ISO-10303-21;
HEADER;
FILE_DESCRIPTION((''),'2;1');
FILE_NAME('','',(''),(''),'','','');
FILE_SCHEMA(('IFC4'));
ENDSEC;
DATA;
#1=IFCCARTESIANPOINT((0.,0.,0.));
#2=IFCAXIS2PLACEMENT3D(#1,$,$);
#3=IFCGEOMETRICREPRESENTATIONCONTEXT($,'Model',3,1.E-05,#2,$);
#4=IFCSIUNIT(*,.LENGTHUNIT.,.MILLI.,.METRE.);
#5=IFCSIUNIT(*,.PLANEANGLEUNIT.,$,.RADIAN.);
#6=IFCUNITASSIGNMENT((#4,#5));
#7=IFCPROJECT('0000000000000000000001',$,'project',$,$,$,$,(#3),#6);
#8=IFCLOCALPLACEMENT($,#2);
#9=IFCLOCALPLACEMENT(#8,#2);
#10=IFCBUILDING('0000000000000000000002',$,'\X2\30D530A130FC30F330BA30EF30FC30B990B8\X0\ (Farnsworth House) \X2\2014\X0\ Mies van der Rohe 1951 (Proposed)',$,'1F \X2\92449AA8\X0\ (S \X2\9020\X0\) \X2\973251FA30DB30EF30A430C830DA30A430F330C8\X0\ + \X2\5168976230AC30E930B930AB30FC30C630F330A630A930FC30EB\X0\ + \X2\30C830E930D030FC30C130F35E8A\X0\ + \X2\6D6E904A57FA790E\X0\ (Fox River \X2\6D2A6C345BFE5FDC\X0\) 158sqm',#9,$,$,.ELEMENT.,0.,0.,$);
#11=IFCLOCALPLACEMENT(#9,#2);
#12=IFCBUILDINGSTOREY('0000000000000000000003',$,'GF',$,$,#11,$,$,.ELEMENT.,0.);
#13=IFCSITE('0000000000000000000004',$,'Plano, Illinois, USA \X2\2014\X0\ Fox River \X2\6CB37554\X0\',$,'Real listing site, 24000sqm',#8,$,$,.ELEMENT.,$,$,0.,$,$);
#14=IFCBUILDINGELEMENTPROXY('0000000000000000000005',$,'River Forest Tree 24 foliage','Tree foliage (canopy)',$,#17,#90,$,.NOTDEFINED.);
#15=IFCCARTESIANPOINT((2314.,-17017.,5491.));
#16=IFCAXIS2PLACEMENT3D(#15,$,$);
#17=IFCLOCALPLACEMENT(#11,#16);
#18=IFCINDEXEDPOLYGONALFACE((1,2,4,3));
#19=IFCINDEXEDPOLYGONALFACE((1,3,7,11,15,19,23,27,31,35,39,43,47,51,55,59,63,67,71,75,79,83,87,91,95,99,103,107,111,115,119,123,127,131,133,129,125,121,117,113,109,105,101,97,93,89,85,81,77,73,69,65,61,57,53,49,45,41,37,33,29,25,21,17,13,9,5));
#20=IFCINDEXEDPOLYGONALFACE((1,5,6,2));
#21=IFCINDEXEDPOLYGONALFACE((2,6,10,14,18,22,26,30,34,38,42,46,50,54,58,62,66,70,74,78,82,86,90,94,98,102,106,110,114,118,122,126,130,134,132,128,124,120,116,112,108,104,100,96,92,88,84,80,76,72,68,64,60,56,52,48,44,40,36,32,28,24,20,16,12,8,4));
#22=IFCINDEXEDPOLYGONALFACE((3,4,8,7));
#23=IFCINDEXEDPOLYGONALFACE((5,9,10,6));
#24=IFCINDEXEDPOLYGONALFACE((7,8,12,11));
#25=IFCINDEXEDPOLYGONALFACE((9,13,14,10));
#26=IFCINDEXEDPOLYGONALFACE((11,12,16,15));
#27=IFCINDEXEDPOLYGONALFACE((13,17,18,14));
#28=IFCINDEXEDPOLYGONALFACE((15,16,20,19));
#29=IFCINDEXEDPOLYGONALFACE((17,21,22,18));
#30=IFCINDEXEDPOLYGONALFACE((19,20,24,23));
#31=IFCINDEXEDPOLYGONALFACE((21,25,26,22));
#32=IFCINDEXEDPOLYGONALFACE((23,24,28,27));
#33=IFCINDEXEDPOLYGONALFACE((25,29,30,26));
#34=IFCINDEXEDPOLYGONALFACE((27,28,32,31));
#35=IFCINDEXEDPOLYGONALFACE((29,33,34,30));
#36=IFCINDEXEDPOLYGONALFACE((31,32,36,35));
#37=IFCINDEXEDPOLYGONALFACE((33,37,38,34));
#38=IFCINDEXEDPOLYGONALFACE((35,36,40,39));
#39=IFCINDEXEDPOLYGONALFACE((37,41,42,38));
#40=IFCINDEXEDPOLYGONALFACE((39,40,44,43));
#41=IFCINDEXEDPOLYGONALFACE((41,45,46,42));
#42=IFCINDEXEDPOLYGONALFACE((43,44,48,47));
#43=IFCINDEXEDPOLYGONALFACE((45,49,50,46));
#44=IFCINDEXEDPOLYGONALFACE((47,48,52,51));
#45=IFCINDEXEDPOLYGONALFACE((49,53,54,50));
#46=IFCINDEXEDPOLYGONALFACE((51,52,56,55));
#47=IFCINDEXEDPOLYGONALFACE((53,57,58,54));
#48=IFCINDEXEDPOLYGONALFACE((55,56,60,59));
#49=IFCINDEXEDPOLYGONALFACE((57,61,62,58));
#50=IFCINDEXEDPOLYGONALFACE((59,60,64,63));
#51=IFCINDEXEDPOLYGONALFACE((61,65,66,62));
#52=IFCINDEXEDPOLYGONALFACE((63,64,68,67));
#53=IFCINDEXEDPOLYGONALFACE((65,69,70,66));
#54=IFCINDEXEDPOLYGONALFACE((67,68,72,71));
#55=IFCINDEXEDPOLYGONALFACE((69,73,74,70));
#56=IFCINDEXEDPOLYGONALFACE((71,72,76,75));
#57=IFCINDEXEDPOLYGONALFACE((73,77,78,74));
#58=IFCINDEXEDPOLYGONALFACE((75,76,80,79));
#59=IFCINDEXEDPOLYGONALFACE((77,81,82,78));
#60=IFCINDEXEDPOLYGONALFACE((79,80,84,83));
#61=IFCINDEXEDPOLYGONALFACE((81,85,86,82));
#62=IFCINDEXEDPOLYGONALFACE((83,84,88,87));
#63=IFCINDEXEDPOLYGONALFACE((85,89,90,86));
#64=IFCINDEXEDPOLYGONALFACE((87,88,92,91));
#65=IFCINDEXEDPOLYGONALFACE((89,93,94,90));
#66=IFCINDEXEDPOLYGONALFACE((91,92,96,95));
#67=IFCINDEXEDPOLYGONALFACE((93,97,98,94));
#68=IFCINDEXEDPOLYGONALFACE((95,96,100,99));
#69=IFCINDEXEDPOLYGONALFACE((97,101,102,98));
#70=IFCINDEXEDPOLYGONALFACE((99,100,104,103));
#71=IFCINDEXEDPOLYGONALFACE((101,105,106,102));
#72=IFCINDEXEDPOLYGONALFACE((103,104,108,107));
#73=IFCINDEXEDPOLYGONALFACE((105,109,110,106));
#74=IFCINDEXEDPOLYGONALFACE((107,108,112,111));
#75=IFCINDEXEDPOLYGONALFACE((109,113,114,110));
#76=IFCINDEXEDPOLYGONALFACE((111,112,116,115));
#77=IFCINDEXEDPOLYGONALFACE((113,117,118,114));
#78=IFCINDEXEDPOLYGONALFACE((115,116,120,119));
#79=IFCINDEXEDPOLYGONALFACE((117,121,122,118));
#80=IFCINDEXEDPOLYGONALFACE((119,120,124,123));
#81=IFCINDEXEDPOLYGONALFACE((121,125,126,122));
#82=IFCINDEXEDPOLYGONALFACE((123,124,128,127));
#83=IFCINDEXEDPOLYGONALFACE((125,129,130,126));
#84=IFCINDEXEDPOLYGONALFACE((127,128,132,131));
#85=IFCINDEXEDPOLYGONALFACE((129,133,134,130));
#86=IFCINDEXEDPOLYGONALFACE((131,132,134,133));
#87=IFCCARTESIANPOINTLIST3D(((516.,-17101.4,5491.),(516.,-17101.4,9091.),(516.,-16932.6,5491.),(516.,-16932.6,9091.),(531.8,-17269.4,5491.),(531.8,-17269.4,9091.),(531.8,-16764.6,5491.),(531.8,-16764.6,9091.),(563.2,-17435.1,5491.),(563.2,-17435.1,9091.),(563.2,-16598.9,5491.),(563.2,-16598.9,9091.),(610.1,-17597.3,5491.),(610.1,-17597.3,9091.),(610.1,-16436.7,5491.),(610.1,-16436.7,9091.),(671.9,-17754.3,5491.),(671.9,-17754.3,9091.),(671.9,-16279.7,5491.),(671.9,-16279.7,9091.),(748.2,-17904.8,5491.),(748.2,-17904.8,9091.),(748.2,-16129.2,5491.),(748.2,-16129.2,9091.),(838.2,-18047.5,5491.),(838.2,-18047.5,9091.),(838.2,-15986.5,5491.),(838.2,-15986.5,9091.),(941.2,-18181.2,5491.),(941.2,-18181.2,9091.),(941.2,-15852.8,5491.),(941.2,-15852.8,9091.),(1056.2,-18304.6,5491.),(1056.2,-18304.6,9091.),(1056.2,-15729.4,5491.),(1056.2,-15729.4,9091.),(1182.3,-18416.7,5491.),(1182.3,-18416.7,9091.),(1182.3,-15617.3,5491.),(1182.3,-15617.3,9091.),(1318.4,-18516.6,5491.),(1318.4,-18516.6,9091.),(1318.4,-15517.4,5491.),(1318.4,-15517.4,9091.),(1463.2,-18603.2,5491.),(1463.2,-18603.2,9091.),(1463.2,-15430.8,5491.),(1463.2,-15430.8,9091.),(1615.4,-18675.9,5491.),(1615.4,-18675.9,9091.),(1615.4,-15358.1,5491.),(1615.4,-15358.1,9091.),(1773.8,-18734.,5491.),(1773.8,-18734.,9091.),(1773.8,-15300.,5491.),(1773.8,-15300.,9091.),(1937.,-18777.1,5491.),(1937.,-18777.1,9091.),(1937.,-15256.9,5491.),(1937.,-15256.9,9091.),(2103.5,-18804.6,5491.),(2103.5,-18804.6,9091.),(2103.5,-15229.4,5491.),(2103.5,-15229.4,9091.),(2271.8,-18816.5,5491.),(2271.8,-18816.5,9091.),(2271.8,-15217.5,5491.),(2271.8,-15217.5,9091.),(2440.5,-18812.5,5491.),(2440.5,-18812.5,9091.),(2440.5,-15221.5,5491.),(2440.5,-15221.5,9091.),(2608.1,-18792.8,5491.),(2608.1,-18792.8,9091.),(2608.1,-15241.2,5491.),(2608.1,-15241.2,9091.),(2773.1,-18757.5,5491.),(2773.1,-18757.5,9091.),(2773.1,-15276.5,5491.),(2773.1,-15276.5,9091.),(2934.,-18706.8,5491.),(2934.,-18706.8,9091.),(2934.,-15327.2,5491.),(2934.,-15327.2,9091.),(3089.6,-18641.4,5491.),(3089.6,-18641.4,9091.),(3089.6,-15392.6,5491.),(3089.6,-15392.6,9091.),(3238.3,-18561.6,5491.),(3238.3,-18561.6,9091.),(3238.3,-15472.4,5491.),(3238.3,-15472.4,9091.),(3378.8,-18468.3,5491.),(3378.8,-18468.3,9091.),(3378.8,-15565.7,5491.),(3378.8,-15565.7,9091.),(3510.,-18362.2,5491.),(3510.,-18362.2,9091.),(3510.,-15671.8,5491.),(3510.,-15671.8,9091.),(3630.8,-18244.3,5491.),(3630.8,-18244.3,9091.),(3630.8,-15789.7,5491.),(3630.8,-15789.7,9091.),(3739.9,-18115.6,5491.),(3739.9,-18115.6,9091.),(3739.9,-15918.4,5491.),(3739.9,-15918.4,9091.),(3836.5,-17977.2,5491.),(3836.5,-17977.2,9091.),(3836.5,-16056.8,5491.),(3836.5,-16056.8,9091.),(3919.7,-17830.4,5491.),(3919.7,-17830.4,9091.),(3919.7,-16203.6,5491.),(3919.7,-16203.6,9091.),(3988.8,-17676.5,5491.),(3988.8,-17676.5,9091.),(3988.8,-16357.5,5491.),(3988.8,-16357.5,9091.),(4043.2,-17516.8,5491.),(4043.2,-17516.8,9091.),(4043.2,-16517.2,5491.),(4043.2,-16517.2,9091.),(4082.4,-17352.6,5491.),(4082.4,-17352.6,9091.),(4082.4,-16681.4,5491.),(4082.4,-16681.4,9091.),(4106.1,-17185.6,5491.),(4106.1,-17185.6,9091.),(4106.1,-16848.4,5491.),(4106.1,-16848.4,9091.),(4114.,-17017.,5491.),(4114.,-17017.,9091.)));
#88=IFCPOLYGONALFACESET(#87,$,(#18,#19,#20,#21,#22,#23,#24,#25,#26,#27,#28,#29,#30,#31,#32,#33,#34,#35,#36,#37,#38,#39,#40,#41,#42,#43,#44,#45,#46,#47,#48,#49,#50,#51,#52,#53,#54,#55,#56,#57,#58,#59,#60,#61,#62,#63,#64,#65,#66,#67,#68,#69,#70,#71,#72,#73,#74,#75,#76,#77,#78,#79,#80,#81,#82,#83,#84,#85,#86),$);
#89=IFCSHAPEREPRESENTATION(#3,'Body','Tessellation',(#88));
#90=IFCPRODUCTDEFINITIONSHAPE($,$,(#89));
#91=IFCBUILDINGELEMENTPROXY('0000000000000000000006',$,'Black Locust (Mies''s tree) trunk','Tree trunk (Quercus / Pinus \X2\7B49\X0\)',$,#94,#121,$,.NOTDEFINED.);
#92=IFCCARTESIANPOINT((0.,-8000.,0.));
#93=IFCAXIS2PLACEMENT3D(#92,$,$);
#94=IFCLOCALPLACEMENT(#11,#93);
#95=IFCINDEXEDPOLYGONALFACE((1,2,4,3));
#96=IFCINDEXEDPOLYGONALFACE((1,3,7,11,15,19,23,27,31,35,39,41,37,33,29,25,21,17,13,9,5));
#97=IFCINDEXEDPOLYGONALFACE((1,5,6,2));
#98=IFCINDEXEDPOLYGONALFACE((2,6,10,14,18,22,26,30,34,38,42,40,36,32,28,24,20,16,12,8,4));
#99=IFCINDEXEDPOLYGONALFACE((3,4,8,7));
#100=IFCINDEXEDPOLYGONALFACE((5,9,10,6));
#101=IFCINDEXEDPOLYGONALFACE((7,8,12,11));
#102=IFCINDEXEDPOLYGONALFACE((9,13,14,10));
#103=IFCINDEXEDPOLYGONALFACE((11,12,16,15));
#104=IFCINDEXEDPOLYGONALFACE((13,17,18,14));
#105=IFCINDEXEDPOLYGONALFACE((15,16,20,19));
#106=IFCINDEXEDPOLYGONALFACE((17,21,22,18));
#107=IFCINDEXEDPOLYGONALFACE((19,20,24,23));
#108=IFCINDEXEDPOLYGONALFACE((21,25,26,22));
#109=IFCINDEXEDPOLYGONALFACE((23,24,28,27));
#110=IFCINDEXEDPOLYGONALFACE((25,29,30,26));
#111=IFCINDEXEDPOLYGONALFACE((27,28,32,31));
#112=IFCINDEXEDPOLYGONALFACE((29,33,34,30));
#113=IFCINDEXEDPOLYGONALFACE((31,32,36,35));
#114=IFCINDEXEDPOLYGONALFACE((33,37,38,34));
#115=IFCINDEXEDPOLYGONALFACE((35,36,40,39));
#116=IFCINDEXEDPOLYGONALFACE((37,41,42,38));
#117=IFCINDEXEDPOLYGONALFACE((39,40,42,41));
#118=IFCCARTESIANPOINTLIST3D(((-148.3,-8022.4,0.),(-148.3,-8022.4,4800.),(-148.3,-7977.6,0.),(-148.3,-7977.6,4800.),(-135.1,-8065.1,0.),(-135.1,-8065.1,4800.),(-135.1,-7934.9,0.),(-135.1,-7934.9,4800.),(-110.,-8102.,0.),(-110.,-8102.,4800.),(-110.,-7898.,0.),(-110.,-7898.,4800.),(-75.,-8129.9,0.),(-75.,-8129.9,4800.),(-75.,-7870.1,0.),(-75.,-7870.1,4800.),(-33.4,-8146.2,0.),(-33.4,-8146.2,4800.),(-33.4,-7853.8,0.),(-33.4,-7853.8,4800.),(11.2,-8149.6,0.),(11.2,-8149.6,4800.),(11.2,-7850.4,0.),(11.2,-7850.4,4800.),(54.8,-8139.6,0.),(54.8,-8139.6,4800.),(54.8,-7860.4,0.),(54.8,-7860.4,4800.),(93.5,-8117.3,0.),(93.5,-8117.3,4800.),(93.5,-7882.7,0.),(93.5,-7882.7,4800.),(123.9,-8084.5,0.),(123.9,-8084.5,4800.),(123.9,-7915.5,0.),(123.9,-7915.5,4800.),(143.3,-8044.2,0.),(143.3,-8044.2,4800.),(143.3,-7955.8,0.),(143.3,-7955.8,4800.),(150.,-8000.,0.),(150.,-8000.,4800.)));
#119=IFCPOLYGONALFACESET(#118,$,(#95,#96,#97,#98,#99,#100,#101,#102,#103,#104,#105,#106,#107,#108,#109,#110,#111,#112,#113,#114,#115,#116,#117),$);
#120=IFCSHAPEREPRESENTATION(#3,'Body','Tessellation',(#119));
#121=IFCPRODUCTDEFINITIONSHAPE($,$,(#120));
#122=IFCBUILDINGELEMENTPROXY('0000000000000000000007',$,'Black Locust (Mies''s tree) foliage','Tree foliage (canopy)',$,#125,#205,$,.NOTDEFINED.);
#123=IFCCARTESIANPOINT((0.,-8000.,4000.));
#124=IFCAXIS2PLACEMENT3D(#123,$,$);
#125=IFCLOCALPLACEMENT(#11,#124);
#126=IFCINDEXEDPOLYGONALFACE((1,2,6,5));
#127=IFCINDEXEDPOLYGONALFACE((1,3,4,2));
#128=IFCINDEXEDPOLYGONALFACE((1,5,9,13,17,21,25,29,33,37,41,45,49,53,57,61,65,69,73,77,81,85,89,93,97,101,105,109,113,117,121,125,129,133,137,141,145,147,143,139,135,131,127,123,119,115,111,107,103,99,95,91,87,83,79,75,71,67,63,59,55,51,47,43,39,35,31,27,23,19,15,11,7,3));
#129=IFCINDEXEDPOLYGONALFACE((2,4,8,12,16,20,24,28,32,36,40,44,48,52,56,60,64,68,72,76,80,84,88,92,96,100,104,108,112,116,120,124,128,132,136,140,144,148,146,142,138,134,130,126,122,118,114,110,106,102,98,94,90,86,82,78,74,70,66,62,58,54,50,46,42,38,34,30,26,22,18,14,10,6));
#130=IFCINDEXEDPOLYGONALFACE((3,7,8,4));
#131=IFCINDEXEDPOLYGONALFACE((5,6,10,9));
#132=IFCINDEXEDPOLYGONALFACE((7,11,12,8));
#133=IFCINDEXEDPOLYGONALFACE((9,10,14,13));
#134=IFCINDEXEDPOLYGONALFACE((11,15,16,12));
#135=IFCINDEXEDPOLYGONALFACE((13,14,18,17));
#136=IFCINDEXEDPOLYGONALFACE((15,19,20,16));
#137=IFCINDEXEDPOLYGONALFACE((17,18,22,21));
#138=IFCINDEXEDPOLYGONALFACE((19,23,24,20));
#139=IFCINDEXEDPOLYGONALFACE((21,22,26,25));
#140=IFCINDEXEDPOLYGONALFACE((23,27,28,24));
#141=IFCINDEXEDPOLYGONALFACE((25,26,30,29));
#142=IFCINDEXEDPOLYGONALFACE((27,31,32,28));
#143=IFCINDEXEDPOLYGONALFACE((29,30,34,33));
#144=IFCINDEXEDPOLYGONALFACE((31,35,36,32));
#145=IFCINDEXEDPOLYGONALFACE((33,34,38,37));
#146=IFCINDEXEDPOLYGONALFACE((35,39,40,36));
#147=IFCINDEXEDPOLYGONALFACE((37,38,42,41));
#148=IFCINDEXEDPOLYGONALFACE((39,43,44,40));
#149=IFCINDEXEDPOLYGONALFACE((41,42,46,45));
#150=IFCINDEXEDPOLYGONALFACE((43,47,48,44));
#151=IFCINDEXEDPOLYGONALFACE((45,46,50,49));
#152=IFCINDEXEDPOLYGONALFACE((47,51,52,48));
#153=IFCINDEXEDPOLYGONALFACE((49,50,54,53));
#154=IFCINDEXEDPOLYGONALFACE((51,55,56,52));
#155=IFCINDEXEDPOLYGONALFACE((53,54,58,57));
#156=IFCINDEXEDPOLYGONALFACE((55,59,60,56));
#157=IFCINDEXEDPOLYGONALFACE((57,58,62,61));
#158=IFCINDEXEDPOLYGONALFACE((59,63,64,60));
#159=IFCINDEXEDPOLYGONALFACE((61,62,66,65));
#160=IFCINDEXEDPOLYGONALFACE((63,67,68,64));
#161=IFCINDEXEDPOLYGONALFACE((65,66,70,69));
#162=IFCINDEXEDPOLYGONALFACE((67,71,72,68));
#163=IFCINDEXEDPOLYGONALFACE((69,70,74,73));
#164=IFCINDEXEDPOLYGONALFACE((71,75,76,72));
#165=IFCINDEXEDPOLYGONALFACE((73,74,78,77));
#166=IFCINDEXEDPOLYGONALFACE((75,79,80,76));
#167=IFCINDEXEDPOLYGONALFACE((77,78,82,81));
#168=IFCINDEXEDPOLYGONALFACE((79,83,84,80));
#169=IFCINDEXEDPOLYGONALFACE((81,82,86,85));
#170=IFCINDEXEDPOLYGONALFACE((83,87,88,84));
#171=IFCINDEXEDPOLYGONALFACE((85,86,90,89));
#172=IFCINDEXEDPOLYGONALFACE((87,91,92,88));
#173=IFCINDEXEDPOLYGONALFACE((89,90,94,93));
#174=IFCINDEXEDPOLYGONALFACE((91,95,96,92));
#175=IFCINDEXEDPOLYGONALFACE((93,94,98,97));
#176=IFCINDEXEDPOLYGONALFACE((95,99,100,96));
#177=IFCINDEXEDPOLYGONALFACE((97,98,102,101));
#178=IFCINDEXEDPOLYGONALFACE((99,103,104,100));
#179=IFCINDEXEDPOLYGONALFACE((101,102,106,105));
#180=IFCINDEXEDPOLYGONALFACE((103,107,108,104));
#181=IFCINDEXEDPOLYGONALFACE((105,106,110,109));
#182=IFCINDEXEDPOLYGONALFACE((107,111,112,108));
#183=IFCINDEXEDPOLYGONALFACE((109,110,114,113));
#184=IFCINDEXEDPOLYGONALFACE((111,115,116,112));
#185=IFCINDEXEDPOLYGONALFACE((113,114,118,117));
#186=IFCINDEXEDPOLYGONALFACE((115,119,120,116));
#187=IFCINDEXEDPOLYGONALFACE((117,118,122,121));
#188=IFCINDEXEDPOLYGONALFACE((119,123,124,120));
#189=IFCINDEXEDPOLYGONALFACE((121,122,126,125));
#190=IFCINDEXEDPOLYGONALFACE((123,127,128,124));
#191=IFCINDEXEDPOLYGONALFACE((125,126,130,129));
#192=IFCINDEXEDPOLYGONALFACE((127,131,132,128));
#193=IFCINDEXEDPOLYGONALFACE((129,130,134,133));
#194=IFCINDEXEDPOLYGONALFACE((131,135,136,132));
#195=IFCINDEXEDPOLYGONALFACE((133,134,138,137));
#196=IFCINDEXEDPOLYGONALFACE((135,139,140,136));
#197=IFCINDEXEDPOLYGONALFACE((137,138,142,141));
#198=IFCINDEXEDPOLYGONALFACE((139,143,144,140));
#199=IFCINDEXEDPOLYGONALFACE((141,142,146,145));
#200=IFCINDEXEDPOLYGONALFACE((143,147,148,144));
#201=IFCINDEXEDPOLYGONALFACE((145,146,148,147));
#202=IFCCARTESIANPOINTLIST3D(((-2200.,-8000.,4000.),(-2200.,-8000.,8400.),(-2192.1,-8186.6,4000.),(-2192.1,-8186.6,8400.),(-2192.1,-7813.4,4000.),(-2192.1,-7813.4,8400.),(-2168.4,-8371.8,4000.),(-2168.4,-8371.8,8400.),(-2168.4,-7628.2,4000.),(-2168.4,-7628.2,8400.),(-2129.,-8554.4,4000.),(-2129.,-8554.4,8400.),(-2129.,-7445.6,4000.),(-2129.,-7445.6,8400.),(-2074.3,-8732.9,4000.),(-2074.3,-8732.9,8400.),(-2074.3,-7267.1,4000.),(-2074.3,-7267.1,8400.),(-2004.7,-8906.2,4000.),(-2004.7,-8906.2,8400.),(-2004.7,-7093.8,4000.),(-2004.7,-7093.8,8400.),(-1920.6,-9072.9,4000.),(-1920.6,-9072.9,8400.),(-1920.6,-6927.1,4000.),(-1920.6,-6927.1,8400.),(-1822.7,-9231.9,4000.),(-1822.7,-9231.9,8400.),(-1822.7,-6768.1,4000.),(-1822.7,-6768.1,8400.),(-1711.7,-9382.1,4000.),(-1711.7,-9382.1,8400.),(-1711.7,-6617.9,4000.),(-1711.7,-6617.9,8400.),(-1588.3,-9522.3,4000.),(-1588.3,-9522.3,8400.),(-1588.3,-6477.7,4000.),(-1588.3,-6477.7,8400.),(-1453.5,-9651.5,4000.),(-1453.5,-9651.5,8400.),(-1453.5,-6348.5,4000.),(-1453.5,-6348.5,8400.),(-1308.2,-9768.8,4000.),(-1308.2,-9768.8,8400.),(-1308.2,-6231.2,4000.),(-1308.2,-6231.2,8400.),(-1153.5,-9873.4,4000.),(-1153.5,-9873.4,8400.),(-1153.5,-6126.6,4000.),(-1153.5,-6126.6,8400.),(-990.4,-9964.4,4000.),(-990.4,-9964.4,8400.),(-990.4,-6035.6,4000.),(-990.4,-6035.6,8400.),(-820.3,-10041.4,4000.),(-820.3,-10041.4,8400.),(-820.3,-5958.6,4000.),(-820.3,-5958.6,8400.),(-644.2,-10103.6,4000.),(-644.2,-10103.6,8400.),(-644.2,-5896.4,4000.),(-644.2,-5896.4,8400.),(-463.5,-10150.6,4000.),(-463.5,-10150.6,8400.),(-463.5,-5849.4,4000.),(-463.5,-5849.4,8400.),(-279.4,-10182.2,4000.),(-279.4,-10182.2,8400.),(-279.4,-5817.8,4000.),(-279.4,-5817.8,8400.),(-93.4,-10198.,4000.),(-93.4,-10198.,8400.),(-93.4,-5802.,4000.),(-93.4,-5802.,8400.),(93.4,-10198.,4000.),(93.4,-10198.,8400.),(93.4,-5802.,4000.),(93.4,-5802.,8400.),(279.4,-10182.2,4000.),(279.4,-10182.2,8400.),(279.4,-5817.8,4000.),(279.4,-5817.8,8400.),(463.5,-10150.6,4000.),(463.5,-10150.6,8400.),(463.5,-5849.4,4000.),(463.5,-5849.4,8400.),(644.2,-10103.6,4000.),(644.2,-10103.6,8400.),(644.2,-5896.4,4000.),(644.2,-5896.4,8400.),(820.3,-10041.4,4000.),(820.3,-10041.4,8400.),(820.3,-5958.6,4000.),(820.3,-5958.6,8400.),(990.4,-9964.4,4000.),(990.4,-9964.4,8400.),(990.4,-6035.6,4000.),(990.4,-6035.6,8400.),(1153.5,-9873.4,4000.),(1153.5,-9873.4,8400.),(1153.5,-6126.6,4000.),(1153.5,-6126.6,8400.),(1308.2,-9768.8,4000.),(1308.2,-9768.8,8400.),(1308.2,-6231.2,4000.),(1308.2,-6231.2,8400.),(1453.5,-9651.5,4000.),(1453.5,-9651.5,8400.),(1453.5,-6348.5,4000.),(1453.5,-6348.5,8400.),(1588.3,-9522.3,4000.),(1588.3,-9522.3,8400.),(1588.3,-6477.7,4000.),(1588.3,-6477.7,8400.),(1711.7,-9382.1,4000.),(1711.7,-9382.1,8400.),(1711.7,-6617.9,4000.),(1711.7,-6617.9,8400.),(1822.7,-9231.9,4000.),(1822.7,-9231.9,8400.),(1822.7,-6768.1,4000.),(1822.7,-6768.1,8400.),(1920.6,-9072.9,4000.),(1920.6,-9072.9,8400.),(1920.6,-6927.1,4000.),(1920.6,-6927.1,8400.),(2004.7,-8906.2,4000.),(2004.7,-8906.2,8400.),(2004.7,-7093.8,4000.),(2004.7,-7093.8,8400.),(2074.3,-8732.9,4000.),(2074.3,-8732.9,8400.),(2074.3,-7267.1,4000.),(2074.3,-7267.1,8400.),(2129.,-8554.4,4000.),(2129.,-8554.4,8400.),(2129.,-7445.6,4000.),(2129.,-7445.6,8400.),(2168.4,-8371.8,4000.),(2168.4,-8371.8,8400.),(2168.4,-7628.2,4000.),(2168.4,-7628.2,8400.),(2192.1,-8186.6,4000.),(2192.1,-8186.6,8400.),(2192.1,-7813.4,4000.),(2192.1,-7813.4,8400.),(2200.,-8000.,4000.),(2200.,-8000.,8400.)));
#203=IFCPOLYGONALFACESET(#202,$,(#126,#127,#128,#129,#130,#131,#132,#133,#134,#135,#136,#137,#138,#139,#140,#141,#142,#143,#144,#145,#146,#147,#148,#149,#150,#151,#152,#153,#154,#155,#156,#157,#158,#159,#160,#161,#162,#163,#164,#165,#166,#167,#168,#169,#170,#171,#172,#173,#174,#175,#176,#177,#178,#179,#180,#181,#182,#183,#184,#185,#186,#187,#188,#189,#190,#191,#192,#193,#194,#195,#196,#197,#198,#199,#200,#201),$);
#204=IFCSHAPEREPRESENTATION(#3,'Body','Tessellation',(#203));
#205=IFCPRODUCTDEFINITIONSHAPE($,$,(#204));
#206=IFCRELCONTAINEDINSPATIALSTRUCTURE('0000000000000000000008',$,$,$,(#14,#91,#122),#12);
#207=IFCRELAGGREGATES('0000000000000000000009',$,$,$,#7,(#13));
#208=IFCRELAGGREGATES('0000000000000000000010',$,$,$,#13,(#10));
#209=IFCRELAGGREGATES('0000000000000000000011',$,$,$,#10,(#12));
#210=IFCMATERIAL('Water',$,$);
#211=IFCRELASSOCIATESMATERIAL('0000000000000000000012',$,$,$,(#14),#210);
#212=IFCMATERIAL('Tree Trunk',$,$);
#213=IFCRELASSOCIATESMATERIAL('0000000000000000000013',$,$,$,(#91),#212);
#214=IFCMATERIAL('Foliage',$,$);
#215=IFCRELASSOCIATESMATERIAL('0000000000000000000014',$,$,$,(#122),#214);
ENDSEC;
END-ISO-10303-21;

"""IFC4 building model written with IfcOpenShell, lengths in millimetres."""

from ifc_helpers import new_model, si_unit, frame, origin, origin_2d, place, context, project, spatial, circle, extrude, material, element, save


model = new_model("IFC4")

# Units and contexts
model_context = context("Model", 3, precision=1e-05, world=origin())
ifc_project = project(units=[si_unit("LENGTHUNIT", "METRE", prefix="MILLI"), si_unit("PLANEANGLEUNIT", "RADIAN")], contexts=[model_context])

# Site, building, storey
site_placement = place(None, origin())
site = spatial("IfcSite", under=ifc_project, at=site_placement, Name="Plano, Illinois, USA — Fox River 河畔", ObjectType="Real listing site, 24000sqm", CompositionType="ELEMENT", RefElevation=0.0)
building_placement = place(site_placement, origin())
building = spatial("IfcBuilding", under=site, at=building_placement, Name="ファーンズワース邸 (Farnsworth House) — Mies van der Rohe 1951 (Proposed)", ObjectType="1F 鉄骨 (S 造) 露出ホワイトペイント + 全面ガラスカーテンウォール + トラバーチン床 + 浮遊基礎 (Fox River 洪水対応) 158sqm", CompositionType="ELEMENT", ElevationOfRefHeight=0.0, ElevationOfTerrain=0.0)
storey_placement = place(building_placement, origin())
storey = spatial("IfcBuildingStorey", under=building, at=storey_placement, Name="GF", CompositionType="ELEMENT", Elevation=0.0)

# Building element proxies
ifc_material_1 = material(Name="Water")
proxy_1_placement = place(storey_placement, frame((2314.0, -17017.0, 5491.0)))
element("IfcBuildingElementProxy", 1, at=proxy_1_placement, inside=storey, material=ifc_material_1, Name="River Forest Tree 24 foliage", Description="Tree foliage (canopy)", PredefinedType="NOTDEFINED", context=model_context, shape_type="SweptSolid", body=[
    extrude(circle(Radius=1800.0, at=origin_2d()), frame((2314.0, -17017.0, 5491.0)), (0.0, 0.0, 1.0), 3600.0),
])
ifc_material_2 = material(Name="Tree Trunk")
proxy_2_placement = place(storey_placement, frame((0.0, -8000.0, 0.0)))
element("IfcBuildingElementProxy", 2, at=proxy_2_placement, inside=storey, material=ifc_material_2, Name="Black Locust (Mies's tree) trunk", Description="Tree trunk (Quercus / Pinus 等)", PredefinedType="NOTDEFINED", context=model_context, shape_type="SweptSolid", body=[
    extrude(circle(Radius=150.0, at=origin_2d()), frame((0.0, -8000.0, 0.0)), (0.0, 0.0, 1.0), 4800.0),
])
ifc_material_3 = material(Name="Foliage")
proxy_3_placement = place(storey_placement, frame((0.0, -8000.0, 4000.0)))
element("IfcBuildingElementProxy", 3, at=proxy_3_placement, inside=storey, material=ifc_material_3, Name="Black Locust (Mies's tree) foliage", Description="Tree foliage (canopy)", PredefinedType="NOTDEFINED", context=model_context, shape_type="SweptSolid", body=[
    extrude(circle(Radius=2200.0, at=origin_2d()), frame((0.0, -8000.0, 4000.0)), (0.0, 0.0, 1.0), 4400.0),
])

save(model, "model.ifc")
